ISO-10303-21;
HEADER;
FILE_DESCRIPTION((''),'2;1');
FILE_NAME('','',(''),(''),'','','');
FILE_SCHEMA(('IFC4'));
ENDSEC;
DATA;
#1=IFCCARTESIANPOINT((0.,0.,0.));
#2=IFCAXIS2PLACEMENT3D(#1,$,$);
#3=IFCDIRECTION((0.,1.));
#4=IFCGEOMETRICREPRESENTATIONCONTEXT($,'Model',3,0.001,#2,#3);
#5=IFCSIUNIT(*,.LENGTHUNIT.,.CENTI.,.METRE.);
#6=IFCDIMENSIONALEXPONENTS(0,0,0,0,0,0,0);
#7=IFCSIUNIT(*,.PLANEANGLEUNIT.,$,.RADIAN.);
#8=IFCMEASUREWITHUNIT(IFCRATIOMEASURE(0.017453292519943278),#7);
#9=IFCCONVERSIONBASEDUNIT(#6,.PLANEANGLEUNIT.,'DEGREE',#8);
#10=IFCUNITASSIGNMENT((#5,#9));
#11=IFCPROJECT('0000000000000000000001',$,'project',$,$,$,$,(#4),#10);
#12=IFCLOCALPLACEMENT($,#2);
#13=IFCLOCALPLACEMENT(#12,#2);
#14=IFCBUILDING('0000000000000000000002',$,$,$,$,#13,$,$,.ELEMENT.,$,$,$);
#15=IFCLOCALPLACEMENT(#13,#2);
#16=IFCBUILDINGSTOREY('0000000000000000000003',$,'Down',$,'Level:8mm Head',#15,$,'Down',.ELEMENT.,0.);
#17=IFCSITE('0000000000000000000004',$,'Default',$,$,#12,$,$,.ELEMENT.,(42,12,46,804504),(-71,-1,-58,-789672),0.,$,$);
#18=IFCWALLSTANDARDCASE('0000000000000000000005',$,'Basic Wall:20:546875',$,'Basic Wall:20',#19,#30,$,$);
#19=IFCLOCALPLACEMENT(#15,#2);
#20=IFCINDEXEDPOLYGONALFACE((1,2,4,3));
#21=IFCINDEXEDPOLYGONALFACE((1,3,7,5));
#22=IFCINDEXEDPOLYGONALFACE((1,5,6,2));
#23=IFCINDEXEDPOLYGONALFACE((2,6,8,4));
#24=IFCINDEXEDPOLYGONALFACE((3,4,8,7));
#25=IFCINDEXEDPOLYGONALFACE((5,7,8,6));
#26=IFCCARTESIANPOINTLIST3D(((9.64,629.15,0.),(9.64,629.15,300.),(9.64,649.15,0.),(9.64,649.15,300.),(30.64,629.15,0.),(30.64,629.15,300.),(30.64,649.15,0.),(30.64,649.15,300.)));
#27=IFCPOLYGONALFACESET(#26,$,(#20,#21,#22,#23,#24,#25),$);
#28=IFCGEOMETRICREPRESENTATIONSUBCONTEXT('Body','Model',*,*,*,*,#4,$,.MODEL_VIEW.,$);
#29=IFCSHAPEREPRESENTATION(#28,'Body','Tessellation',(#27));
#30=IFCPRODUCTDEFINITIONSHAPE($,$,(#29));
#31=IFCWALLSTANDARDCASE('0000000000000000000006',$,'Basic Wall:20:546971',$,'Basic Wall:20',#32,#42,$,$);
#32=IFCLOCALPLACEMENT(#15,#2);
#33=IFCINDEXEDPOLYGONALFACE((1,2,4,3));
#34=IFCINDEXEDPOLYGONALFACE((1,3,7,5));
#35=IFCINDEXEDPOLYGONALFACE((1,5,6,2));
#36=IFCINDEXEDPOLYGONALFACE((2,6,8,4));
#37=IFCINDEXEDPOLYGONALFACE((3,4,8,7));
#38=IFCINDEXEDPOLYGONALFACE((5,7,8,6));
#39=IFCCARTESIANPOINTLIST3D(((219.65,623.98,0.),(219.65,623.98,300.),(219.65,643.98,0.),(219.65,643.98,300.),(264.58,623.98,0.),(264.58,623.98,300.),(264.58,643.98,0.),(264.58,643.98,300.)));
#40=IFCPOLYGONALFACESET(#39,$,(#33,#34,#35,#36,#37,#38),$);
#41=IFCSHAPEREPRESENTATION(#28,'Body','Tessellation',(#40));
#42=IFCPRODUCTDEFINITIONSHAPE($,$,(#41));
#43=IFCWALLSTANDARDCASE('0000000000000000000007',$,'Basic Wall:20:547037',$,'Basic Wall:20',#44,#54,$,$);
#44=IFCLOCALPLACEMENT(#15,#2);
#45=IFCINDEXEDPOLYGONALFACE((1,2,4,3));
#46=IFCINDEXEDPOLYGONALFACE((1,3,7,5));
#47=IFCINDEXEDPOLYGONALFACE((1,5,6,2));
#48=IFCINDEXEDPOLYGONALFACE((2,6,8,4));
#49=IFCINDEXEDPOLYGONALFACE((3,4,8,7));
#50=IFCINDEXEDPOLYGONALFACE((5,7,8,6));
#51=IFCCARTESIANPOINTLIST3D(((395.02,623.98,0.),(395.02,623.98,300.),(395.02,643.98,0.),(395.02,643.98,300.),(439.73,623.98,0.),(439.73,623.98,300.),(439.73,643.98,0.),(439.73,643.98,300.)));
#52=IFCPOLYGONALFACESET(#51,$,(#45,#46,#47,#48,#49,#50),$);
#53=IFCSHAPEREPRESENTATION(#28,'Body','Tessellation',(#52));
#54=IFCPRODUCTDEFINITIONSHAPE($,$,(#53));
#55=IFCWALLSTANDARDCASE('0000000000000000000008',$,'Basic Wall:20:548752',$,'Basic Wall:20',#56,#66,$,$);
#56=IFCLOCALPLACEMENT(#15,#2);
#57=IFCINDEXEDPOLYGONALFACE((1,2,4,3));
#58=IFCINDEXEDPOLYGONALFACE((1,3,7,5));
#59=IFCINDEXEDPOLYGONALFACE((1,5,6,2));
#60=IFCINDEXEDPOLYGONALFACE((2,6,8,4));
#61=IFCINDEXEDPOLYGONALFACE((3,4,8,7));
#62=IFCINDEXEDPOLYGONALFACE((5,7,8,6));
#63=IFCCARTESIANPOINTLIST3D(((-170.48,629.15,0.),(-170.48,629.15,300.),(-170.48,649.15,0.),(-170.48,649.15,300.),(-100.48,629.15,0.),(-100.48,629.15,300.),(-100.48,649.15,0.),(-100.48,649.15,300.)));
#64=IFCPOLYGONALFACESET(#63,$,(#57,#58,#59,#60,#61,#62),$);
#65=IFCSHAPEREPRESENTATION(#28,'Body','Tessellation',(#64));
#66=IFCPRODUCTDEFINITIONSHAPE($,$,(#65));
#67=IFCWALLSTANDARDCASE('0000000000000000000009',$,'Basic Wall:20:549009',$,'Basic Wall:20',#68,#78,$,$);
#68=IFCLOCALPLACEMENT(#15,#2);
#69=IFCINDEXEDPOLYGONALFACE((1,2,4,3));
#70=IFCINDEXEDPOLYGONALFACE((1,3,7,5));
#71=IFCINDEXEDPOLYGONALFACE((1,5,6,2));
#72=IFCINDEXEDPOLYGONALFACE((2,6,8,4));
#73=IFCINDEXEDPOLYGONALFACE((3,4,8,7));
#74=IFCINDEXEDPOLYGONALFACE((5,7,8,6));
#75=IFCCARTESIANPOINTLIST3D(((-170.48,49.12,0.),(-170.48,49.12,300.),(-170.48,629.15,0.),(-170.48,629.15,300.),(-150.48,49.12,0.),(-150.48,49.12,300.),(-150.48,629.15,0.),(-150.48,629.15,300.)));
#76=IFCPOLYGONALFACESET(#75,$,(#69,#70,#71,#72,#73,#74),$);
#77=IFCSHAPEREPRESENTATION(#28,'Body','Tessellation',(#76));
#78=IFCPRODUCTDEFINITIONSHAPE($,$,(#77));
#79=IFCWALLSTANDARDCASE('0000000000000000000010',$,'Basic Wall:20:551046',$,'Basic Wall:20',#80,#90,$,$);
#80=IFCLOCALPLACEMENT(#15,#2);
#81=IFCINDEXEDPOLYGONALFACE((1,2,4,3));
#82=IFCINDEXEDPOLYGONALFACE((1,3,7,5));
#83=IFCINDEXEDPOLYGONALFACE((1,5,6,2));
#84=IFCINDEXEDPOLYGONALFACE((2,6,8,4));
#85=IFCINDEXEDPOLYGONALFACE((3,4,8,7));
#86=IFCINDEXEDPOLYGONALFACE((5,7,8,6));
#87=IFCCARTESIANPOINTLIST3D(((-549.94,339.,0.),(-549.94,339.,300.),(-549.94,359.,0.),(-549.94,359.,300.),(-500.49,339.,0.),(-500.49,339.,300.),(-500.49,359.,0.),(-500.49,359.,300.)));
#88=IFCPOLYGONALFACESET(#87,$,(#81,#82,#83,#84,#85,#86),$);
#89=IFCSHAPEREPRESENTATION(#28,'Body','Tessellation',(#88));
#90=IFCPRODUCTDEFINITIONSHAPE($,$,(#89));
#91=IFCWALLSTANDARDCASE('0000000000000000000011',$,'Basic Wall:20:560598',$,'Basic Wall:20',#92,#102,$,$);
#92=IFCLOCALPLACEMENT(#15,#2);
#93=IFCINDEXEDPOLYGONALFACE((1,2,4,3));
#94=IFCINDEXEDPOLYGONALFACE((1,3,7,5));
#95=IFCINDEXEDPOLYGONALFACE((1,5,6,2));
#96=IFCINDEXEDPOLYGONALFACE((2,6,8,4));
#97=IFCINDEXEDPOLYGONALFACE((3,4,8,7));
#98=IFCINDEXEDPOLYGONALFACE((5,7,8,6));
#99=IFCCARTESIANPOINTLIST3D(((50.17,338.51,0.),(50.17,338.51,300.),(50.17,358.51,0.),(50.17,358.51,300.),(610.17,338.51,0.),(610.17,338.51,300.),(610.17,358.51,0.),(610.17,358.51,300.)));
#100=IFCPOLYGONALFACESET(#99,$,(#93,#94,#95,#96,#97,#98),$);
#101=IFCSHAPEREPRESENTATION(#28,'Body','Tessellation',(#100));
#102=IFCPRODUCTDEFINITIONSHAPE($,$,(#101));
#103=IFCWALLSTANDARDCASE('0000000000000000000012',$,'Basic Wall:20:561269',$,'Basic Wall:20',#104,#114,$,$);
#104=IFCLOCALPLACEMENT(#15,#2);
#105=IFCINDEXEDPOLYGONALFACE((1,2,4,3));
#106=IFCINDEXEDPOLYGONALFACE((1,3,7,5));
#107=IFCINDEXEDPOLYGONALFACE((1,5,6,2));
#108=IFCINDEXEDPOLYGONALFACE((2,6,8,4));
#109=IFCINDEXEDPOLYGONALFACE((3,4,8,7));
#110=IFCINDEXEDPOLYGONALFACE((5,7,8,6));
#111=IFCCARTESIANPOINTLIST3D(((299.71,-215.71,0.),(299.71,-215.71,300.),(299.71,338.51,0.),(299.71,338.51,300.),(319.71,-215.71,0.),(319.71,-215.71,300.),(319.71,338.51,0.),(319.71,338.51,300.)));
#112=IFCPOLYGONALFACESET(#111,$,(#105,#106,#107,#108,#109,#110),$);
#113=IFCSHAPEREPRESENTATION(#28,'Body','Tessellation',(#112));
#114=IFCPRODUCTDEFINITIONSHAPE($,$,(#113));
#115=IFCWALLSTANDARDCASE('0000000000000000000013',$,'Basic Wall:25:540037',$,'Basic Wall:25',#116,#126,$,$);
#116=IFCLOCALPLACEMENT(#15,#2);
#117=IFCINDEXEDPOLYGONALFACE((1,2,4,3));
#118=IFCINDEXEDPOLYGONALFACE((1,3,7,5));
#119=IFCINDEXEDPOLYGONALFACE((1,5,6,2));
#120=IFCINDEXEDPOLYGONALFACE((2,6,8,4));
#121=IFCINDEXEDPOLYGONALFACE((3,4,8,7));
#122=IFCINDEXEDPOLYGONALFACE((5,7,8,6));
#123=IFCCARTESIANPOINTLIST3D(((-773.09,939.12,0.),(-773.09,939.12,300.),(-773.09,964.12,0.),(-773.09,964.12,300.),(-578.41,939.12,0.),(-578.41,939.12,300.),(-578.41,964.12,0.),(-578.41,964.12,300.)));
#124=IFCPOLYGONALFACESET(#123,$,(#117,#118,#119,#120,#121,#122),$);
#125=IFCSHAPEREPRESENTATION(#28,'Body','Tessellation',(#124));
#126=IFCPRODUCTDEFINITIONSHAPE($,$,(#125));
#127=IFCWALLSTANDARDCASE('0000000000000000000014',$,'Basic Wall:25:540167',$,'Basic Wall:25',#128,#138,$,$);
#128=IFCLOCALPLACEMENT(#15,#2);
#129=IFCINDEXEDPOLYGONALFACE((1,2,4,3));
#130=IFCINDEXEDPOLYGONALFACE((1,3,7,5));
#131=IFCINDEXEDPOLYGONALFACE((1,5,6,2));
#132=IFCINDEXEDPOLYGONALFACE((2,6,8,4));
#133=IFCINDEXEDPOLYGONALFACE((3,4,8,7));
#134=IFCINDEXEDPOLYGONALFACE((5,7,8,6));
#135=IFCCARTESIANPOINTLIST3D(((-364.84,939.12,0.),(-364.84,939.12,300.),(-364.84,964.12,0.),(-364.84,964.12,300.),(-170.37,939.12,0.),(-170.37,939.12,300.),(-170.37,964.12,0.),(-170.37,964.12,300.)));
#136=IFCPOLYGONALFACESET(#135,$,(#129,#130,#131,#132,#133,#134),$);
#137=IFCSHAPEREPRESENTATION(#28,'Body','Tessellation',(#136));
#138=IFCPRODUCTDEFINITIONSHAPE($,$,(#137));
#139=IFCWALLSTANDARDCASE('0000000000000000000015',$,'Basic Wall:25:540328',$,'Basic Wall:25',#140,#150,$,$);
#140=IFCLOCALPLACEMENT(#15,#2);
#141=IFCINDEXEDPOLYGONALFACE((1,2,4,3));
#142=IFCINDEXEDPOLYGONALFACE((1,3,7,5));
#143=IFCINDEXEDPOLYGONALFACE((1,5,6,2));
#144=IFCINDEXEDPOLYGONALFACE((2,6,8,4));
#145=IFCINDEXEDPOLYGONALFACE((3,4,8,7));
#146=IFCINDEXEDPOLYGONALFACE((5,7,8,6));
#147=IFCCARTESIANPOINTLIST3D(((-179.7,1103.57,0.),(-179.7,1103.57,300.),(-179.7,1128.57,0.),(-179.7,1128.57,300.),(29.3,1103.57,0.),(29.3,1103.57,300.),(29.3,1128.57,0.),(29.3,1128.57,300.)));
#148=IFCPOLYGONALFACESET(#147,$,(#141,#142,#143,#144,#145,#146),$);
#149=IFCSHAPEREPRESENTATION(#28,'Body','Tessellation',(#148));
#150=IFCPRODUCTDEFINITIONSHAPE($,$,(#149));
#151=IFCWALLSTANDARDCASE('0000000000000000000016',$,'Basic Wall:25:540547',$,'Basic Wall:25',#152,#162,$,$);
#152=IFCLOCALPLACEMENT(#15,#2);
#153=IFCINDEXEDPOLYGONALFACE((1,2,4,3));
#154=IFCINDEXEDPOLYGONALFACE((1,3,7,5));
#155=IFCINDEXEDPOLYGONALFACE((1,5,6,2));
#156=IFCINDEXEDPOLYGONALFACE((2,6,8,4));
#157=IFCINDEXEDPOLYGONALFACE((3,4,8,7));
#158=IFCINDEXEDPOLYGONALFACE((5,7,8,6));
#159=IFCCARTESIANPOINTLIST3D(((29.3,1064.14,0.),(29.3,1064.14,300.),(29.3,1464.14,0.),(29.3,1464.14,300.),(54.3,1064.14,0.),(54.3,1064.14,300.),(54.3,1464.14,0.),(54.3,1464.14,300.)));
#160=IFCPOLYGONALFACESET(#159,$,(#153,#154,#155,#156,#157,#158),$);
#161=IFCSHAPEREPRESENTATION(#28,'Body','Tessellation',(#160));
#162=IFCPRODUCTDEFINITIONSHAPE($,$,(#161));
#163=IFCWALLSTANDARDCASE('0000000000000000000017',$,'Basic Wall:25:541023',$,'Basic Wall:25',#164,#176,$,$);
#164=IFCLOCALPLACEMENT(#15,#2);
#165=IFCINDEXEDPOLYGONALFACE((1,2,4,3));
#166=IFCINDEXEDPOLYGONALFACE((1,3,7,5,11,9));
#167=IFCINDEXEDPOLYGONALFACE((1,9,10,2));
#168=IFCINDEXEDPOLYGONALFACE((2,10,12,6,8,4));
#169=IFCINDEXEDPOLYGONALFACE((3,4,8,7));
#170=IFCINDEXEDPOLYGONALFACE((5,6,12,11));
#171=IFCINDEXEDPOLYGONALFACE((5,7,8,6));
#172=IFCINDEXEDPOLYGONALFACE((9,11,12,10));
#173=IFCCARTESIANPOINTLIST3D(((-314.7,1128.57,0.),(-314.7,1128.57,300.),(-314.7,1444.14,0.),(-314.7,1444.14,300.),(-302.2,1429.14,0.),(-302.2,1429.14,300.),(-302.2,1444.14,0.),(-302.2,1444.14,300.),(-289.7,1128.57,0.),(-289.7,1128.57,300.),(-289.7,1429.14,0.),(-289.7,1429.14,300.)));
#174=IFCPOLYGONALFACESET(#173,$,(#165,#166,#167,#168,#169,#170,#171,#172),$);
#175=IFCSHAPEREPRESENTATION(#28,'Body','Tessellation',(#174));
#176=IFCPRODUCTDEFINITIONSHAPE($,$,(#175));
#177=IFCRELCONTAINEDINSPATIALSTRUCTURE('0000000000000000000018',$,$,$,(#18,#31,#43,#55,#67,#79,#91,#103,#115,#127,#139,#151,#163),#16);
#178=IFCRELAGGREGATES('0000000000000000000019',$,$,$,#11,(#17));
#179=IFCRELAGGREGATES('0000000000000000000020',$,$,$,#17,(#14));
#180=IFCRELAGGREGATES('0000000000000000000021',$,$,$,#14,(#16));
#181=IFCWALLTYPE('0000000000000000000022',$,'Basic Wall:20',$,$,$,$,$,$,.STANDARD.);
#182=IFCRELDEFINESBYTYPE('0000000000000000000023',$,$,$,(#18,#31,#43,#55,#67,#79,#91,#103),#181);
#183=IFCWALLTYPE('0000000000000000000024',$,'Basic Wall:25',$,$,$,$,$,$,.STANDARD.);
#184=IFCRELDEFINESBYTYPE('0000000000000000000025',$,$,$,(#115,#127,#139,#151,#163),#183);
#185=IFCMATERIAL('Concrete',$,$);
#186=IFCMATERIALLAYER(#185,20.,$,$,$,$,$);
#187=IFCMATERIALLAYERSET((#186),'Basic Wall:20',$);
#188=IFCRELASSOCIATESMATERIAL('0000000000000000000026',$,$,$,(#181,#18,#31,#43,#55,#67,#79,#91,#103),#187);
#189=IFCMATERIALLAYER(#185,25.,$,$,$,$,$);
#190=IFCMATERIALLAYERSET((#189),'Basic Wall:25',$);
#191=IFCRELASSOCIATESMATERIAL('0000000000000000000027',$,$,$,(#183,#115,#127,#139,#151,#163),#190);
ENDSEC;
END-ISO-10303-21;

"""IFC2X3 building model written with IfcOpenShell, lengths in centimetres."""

from ifc_helpers import new_model, entity, si_unit, converted_unit, direction, frame, frame_2d, origin, place, context, subcontext, project, spatial, polyline, rectangle, outline, extrude, material, layer, layer_set, layer_usage, type_object, element, save


model = new_model("IFC2X3")

# Units and contexts
model_context = context("Model", 3, precision=0.001, world=origin(), true_north=direction((0.0, 1.0)))
body_context = subcontext(model_context, "Body", "Model", "MODEL_VIEW")
ifc_project = project(units=[si_unit("LENGTHUNIT", "METRE", prefix="CENTI"), converted_unit("PLANEANGLEUNIT", "DEGREE", entity("IfcRatioMeasure", 0.017453292519943278), si_unit("PLANEANGLEUNIT", "RADIAN"), dimensions=[0, 0, 0, 0, 0, 0, 0])], contexts=[model_context])

# Site, building, storey
site_placement = place(None, origin())
site = spatial("IfcSite", under=ifc_project, at=site_placement, Name="Default", CompositionType="ELEMENT", RefLatitude=(42, 12, 46, 804504), RefLongitude=(-71, -1, -58, -789672), RefElevation=0.0)
building_placement = place(site_placement, origin())
building = spatial("IfcBuilding", under=site, at=building_placement, CompositionType="ELEMENT")
storey_placement = place(building_placement, origin())
storey = spatial("IfcBuildingStorey", under=building, at=storey_placement, Name="Down", ObjectType="Level:8mm Head", LongName="Down", CompositionType="ELEMENT", Elevation=0.0)

# Walls
ifc_material = material(Name="Concrete")
ifc_layer_1 = layer(ifc_material, 20.0)
ifc_layer_set_1 = layer_set([ifc_layer_1], Name="Basic Wall:20")
wall_type_1 = type_object("IfcWallType", Name="Basic Wall:20", PredefinedType="STANDARD", material=ifc_layer_set_1)
ifc_layer_usage_1 = layer_usage(ifc_layer_set_1, "AXIS2", "POSITIVE", -10.0)
wall_1_placement = place(storey_placement, frame((30.64, 639.15, 0.0), z_axis=(0.0, 0.0, 1.0), x_axis=(-1.0, 0.0, 0.0)))
element("IfcWallStandardCase", 1, at=wall_1_placement, inside=storey, type_object=wall_type_1, material=ifc_layer_usage_1, Name="Basic Wall:20:546875", ObjectType="Basic Wall:20", context=body_context, shape_type="SweptSolid", body=[
    extrude(rectangle(XDim=21.0, YDim=20.0, at=frame_2d((10.5, 0.0), x_axis=(-1.0, 0.0))), origin(), (0.0, 0.0, 1.0), 300.0),
])
ifc_layer_usage_2 = layer_usage(ifc_layer_set_1, "AXIS2", "POSITIVE", -10.0)
wall_2_placement = place(storey_placement, frame((219.65, 633.98, 0.0)))
element("IfcWallStandardCase", 2, at=wall_2_placement, inside=storey, type_object=wall_type_1, material=ifc_layer_usage_2, Name="Basic Wall:20:546971", ObjectType="Basic Wall:20", context=body_context, shape_type="SweptSolid", body=[
    extrude(rectangle(XDim=44.93, YDim=20.0, at=frame_2d((22.46, 0.0), x_axis=(-1.0, 0.0))), origin(), (0.0, 0.0, 1.0), 300.0),
])
ifc_layer_usage_3 = layer_usage(ifc_layer_set_1, "AXIS2", "POSITIVE", -10.0)
wall_3_placement = place(storey_placement, frame((395.02, 633.98, 0.0)))
element("IfcWallStandardCase", 3, at=wall_3_placement, inside=storey, type_object=wall_type_1, material=ifc_layer_usage_3, Name="Basic Wall:20:547037", ObjectType="Basic Wall:20", context=body_context, shape_type="SweptSolid", body=[
    extrude(rectangle(XDim=44.71, YDim=20.0, at=frame_2d((22.36, 0.0), x_axis=(-1.0, 0.0))), origin(), (0.0, 0.0, 1.0), 300.0),
])
ifc_layer_usage_4 = layer_usage(ifc_layer_set_1, "AXIS2", "NEGATIVE", 10.0)
wall_4_placement = place(storey_placement, frame((-100.48, 639.15, 0.0), z_axis=(0.0, 0.0, 1.0), x_axis=(-1.0, 0.0, 0.0)))
element("IfcWallStandardCase", 4, at=wall_4_placement, inside=storey, type_object=wall_type_1, material=ifc_layer_usage_4, Name="Basic Wall:20:548752", ObjectType="Basic Wall:20", context=body_context, shape_type="SweptSolid", body=[
    extrude(rectangle(XDim=70.0, YDim=20.0, at=frame_2d((35.0, 0.0), x_axis=(-1.0, 0.0))), origin(), (0.0, 0.0, 1.0), 300.0),
])
ifc_layer_usage_5 = layer_usage(ifc_layer_set_1, "AXIS2", "POSITIVE", -10.0)
wall_5_placement = place(storey_placement, frame((-160.48, 629.15, 0.0), z_axis=(0.0, 0.0, 1.0), x_axis=(0.0, -1.0, 0.0)))
element("IfcWallStandardCase", 5, at=wall_5_placement, inside=storey, type_object=wall_type_1, material=ifc_layer_usage_5, Name="Basic Wall:20:549009", ObjectType="Basic Wall:20", context=body_context, shape_type="SweptSolid", body=[
    extrude(rectangle(XDim=580.03, YDim=20.0, at=frame_2d((290.02, 0.0), x_axis=(-1.0, 0.0))), origin(), (0.0, 0.0, 1.0), 300.0),
])
ifc_layer_usage_6 = layer_usage(ifc_layer_set_1, "AXIS2", "NEGATIVE", 10.0)
wall_6_placement = place(storey_placement, frame((-500.49, 349.0, 0.0), z_axis=(0.0, 0.0, 1.0), x_axis=(-1.0, 0.0, 0.0)))
element("IfcWallStandardCase", 6, at=wall_6_placement, inside=storey, type_object=wall_type_1, material=ifc_layer_usage_6, Name="Basic Wall:20:551046", ObjectType="Basic Wall:20", context=body_context, shape_type="SweptSolid", body=[
    extrude(rectangle(XDim=49.45, YDim=20.0, at=frame_2d((24.73, 0.0), x_axis=(-1.0, 0.0))), origin(), (0.0, 0.0, 1.0), 300.0),
])
ifc_layer_usage_7 = layer_usage(ifc_layer_set_1, "AXIS2", "POSITIVE", -10.0)
wall_7_placement = place(storey_placement, frame((50.17, 348.51, 0.0)))
element("IfcWallStandardCase", 7, at=wall_7_placement, inside=storey, type_object=wall_type_1, material=ifc_layer_usage_7, Name="Basic Wall:20:560598", ObjectType="Basic Wall:20", context=body_context, shape_type="SweptSolid", body=[
    extrude(rectangle(XDim=560.0, YDim=20.0, at=frame_2d((280.0, 0.0), x_axis=(-1.0, 0.0))), origin(), (0.0, 0.0, 1.0), 300.0),
])
ifc_layer_usage_8 = layer_usage(ifc_layer_set_1, "AXIS2", "NEGATIVE", 10.0)
wall_8_placement = place(storey_placement, frame((309.71, 338.51, 0.0), z_axis=(0.0, 0.0, 1.0), x_axis=(0.0, -1.0, 0.0)))
element("IfcWallStandardCase", 8, at=wall_8_placement, inside=storey, type_object=wall_type_1, material=ifc_layer_usage_8, Name="Basic Wall:20:561269", ObjectType="Basic Wall:20", context=body_context, shape_type="SweptSolid", body=[
    extrude(rectangle(XDim=554.21, YDim=20.0, at=frame_2d((277.11, 0.0), x_axis=(-1.0, 0.0))), origin(), (0.0, 0.0, 1.0), 300.0),
])
ifc_layer_2 = layer(ifc_material, 25.0)
ifc_layer_set_2 = layer_set([ifc_layer_2], Name="Basic Wall:25")
ifc_layer_usage_9 = layer_usage(ifc_layer_set_2, "AXIS2", "POSITIVE", -12.5)
wall_type_2 = type_object("IfcWallType", Name="Basic Wall:25", PredefinedType="STANDARD", material=ifc_layer_set_2)
wall_9_placement = place(storey_placement, frame((-773.09, 951.62, 0.0)))
element("IfcWallStandardCase", 9, at=wall_9_placement, inside=storey, type_object=wall_type_2, material=ifc_layer_usage_9, Name="Basic Wall:25:540037", ObjectType="Basic Wall:25", context=body_context, shape_type="SweptSolid", body=[
    extrude(rectangle(XDim=194.69, YDim=25.0, at=frame_2d((97.34, 0.0), x_axis=(-1.0, 0.0))), origin(), (0.0, 0.0, 1.0), 300.0),
])
ifc_layer_usage_10 = layer_usage(ifc_layer_set_2, "AXIS2", "POSITIVE", -12.5)
wall_10_placement = place(storey_placement, frame((-364.84, 951.62, 0.0)))
element("IfcWallStandardCase", 10, at=wall_10_placement, inside=storey, type_object=wall_type_2, material=ifc_layer_usage_10, Name="Basic Wall:25:540167", ObjectType="Basic Wall:25", context=body_context, shape_type="SweptSolid", body=[
    extrude(rectangle(XDim=194.47, YDim=25.0, at=frame_2d((97.23, 0.0), x_axis=(-1.0, 0.0))), origin(), (0.0, 0.0, 1.0), 300.0),
])
ifc_layer_usage_11 = layer_usage(ifc_layer_set_2, "AXIS2", "POSITIVE", -12.5)
wall_11_placement = place(storey_placement, frame((-179.7, 1116.07, 0.0)))
element("IfcWallStandardCase", 11, at=wall_11_placement, inside=storey, type_object=wall_type_2, material=ifc_layer_usage_11, Name="Basic Wall:25:540328", ObjectType="Basic Wall:25", context=body_context, shape_type="SweptSolid", body=[
    extrude(rectangle(XDim=209.0, YDim=25.0, at=frame_2d((104.5, 0.0), x_axis=(-1.0, 0.0))), origin(), (0.0, 0.0, 1.0), 300.0),
])
ifc_layer_usage_12 = layer_usage(ifc_layer_set_2, "AXIS2", "POSITIVE", -12.5)
wall_12_placement = place(storey_placement, frame((41.8, 1064.14, 0.0), z_axis=(0.0, 0.0, 1.0), x_axis=(0.0, 1.0, 0.0)))
element("IfcWallStandardCase", 12, at=wall_12_placement, inside=storey, type_object=wall_type_2, material=ifc_layer_usage_12, Name="Basic Wall:25:540547", ObjectType="Basic Wall:25", context=body_context, shape_type="SweptSolid", body=[
    extrude(rectangle(XDim=400.01, YDim=25.0, at=frame_2d((200.0, 0.0), x_axis=(-1.0, 0.0))), origin(), (0.0, 0.0, 1.0), 300.0),
])
ifc_layer_usage_13 = layer_usage(ifc_layer_set_2, "AXIS2", "POSITIVE", -12.5)
wall_13_placement = place(storey_placement, frame((-302.2, 1444.14, 0.0), z_axis=(0.0, 0.0, 1.0), x_axis=(0.0, -1.0, 0.0)))
element("IfcWallStandardCase", 13, at=wall_13_placement, inside=storey, type_object=wall_type_2, material=ifc_layer_usage_13, Name="Basic Wall:25:541023", ObjectType="Basic Wall:25", context=body_context, shape_type="SweptSolid", body=[
    extrude(outline(polyline([(315.57, -12.5), (315.57, 12.5), (15.0, 12.5), (15.0, 0.0), (0.0, 0.0), (0.0, -12.5), (315.57, -12.5)])), origin(), (0.0, 0.0, 1.0), 300.0),
])

save(model, "model.ifc")
